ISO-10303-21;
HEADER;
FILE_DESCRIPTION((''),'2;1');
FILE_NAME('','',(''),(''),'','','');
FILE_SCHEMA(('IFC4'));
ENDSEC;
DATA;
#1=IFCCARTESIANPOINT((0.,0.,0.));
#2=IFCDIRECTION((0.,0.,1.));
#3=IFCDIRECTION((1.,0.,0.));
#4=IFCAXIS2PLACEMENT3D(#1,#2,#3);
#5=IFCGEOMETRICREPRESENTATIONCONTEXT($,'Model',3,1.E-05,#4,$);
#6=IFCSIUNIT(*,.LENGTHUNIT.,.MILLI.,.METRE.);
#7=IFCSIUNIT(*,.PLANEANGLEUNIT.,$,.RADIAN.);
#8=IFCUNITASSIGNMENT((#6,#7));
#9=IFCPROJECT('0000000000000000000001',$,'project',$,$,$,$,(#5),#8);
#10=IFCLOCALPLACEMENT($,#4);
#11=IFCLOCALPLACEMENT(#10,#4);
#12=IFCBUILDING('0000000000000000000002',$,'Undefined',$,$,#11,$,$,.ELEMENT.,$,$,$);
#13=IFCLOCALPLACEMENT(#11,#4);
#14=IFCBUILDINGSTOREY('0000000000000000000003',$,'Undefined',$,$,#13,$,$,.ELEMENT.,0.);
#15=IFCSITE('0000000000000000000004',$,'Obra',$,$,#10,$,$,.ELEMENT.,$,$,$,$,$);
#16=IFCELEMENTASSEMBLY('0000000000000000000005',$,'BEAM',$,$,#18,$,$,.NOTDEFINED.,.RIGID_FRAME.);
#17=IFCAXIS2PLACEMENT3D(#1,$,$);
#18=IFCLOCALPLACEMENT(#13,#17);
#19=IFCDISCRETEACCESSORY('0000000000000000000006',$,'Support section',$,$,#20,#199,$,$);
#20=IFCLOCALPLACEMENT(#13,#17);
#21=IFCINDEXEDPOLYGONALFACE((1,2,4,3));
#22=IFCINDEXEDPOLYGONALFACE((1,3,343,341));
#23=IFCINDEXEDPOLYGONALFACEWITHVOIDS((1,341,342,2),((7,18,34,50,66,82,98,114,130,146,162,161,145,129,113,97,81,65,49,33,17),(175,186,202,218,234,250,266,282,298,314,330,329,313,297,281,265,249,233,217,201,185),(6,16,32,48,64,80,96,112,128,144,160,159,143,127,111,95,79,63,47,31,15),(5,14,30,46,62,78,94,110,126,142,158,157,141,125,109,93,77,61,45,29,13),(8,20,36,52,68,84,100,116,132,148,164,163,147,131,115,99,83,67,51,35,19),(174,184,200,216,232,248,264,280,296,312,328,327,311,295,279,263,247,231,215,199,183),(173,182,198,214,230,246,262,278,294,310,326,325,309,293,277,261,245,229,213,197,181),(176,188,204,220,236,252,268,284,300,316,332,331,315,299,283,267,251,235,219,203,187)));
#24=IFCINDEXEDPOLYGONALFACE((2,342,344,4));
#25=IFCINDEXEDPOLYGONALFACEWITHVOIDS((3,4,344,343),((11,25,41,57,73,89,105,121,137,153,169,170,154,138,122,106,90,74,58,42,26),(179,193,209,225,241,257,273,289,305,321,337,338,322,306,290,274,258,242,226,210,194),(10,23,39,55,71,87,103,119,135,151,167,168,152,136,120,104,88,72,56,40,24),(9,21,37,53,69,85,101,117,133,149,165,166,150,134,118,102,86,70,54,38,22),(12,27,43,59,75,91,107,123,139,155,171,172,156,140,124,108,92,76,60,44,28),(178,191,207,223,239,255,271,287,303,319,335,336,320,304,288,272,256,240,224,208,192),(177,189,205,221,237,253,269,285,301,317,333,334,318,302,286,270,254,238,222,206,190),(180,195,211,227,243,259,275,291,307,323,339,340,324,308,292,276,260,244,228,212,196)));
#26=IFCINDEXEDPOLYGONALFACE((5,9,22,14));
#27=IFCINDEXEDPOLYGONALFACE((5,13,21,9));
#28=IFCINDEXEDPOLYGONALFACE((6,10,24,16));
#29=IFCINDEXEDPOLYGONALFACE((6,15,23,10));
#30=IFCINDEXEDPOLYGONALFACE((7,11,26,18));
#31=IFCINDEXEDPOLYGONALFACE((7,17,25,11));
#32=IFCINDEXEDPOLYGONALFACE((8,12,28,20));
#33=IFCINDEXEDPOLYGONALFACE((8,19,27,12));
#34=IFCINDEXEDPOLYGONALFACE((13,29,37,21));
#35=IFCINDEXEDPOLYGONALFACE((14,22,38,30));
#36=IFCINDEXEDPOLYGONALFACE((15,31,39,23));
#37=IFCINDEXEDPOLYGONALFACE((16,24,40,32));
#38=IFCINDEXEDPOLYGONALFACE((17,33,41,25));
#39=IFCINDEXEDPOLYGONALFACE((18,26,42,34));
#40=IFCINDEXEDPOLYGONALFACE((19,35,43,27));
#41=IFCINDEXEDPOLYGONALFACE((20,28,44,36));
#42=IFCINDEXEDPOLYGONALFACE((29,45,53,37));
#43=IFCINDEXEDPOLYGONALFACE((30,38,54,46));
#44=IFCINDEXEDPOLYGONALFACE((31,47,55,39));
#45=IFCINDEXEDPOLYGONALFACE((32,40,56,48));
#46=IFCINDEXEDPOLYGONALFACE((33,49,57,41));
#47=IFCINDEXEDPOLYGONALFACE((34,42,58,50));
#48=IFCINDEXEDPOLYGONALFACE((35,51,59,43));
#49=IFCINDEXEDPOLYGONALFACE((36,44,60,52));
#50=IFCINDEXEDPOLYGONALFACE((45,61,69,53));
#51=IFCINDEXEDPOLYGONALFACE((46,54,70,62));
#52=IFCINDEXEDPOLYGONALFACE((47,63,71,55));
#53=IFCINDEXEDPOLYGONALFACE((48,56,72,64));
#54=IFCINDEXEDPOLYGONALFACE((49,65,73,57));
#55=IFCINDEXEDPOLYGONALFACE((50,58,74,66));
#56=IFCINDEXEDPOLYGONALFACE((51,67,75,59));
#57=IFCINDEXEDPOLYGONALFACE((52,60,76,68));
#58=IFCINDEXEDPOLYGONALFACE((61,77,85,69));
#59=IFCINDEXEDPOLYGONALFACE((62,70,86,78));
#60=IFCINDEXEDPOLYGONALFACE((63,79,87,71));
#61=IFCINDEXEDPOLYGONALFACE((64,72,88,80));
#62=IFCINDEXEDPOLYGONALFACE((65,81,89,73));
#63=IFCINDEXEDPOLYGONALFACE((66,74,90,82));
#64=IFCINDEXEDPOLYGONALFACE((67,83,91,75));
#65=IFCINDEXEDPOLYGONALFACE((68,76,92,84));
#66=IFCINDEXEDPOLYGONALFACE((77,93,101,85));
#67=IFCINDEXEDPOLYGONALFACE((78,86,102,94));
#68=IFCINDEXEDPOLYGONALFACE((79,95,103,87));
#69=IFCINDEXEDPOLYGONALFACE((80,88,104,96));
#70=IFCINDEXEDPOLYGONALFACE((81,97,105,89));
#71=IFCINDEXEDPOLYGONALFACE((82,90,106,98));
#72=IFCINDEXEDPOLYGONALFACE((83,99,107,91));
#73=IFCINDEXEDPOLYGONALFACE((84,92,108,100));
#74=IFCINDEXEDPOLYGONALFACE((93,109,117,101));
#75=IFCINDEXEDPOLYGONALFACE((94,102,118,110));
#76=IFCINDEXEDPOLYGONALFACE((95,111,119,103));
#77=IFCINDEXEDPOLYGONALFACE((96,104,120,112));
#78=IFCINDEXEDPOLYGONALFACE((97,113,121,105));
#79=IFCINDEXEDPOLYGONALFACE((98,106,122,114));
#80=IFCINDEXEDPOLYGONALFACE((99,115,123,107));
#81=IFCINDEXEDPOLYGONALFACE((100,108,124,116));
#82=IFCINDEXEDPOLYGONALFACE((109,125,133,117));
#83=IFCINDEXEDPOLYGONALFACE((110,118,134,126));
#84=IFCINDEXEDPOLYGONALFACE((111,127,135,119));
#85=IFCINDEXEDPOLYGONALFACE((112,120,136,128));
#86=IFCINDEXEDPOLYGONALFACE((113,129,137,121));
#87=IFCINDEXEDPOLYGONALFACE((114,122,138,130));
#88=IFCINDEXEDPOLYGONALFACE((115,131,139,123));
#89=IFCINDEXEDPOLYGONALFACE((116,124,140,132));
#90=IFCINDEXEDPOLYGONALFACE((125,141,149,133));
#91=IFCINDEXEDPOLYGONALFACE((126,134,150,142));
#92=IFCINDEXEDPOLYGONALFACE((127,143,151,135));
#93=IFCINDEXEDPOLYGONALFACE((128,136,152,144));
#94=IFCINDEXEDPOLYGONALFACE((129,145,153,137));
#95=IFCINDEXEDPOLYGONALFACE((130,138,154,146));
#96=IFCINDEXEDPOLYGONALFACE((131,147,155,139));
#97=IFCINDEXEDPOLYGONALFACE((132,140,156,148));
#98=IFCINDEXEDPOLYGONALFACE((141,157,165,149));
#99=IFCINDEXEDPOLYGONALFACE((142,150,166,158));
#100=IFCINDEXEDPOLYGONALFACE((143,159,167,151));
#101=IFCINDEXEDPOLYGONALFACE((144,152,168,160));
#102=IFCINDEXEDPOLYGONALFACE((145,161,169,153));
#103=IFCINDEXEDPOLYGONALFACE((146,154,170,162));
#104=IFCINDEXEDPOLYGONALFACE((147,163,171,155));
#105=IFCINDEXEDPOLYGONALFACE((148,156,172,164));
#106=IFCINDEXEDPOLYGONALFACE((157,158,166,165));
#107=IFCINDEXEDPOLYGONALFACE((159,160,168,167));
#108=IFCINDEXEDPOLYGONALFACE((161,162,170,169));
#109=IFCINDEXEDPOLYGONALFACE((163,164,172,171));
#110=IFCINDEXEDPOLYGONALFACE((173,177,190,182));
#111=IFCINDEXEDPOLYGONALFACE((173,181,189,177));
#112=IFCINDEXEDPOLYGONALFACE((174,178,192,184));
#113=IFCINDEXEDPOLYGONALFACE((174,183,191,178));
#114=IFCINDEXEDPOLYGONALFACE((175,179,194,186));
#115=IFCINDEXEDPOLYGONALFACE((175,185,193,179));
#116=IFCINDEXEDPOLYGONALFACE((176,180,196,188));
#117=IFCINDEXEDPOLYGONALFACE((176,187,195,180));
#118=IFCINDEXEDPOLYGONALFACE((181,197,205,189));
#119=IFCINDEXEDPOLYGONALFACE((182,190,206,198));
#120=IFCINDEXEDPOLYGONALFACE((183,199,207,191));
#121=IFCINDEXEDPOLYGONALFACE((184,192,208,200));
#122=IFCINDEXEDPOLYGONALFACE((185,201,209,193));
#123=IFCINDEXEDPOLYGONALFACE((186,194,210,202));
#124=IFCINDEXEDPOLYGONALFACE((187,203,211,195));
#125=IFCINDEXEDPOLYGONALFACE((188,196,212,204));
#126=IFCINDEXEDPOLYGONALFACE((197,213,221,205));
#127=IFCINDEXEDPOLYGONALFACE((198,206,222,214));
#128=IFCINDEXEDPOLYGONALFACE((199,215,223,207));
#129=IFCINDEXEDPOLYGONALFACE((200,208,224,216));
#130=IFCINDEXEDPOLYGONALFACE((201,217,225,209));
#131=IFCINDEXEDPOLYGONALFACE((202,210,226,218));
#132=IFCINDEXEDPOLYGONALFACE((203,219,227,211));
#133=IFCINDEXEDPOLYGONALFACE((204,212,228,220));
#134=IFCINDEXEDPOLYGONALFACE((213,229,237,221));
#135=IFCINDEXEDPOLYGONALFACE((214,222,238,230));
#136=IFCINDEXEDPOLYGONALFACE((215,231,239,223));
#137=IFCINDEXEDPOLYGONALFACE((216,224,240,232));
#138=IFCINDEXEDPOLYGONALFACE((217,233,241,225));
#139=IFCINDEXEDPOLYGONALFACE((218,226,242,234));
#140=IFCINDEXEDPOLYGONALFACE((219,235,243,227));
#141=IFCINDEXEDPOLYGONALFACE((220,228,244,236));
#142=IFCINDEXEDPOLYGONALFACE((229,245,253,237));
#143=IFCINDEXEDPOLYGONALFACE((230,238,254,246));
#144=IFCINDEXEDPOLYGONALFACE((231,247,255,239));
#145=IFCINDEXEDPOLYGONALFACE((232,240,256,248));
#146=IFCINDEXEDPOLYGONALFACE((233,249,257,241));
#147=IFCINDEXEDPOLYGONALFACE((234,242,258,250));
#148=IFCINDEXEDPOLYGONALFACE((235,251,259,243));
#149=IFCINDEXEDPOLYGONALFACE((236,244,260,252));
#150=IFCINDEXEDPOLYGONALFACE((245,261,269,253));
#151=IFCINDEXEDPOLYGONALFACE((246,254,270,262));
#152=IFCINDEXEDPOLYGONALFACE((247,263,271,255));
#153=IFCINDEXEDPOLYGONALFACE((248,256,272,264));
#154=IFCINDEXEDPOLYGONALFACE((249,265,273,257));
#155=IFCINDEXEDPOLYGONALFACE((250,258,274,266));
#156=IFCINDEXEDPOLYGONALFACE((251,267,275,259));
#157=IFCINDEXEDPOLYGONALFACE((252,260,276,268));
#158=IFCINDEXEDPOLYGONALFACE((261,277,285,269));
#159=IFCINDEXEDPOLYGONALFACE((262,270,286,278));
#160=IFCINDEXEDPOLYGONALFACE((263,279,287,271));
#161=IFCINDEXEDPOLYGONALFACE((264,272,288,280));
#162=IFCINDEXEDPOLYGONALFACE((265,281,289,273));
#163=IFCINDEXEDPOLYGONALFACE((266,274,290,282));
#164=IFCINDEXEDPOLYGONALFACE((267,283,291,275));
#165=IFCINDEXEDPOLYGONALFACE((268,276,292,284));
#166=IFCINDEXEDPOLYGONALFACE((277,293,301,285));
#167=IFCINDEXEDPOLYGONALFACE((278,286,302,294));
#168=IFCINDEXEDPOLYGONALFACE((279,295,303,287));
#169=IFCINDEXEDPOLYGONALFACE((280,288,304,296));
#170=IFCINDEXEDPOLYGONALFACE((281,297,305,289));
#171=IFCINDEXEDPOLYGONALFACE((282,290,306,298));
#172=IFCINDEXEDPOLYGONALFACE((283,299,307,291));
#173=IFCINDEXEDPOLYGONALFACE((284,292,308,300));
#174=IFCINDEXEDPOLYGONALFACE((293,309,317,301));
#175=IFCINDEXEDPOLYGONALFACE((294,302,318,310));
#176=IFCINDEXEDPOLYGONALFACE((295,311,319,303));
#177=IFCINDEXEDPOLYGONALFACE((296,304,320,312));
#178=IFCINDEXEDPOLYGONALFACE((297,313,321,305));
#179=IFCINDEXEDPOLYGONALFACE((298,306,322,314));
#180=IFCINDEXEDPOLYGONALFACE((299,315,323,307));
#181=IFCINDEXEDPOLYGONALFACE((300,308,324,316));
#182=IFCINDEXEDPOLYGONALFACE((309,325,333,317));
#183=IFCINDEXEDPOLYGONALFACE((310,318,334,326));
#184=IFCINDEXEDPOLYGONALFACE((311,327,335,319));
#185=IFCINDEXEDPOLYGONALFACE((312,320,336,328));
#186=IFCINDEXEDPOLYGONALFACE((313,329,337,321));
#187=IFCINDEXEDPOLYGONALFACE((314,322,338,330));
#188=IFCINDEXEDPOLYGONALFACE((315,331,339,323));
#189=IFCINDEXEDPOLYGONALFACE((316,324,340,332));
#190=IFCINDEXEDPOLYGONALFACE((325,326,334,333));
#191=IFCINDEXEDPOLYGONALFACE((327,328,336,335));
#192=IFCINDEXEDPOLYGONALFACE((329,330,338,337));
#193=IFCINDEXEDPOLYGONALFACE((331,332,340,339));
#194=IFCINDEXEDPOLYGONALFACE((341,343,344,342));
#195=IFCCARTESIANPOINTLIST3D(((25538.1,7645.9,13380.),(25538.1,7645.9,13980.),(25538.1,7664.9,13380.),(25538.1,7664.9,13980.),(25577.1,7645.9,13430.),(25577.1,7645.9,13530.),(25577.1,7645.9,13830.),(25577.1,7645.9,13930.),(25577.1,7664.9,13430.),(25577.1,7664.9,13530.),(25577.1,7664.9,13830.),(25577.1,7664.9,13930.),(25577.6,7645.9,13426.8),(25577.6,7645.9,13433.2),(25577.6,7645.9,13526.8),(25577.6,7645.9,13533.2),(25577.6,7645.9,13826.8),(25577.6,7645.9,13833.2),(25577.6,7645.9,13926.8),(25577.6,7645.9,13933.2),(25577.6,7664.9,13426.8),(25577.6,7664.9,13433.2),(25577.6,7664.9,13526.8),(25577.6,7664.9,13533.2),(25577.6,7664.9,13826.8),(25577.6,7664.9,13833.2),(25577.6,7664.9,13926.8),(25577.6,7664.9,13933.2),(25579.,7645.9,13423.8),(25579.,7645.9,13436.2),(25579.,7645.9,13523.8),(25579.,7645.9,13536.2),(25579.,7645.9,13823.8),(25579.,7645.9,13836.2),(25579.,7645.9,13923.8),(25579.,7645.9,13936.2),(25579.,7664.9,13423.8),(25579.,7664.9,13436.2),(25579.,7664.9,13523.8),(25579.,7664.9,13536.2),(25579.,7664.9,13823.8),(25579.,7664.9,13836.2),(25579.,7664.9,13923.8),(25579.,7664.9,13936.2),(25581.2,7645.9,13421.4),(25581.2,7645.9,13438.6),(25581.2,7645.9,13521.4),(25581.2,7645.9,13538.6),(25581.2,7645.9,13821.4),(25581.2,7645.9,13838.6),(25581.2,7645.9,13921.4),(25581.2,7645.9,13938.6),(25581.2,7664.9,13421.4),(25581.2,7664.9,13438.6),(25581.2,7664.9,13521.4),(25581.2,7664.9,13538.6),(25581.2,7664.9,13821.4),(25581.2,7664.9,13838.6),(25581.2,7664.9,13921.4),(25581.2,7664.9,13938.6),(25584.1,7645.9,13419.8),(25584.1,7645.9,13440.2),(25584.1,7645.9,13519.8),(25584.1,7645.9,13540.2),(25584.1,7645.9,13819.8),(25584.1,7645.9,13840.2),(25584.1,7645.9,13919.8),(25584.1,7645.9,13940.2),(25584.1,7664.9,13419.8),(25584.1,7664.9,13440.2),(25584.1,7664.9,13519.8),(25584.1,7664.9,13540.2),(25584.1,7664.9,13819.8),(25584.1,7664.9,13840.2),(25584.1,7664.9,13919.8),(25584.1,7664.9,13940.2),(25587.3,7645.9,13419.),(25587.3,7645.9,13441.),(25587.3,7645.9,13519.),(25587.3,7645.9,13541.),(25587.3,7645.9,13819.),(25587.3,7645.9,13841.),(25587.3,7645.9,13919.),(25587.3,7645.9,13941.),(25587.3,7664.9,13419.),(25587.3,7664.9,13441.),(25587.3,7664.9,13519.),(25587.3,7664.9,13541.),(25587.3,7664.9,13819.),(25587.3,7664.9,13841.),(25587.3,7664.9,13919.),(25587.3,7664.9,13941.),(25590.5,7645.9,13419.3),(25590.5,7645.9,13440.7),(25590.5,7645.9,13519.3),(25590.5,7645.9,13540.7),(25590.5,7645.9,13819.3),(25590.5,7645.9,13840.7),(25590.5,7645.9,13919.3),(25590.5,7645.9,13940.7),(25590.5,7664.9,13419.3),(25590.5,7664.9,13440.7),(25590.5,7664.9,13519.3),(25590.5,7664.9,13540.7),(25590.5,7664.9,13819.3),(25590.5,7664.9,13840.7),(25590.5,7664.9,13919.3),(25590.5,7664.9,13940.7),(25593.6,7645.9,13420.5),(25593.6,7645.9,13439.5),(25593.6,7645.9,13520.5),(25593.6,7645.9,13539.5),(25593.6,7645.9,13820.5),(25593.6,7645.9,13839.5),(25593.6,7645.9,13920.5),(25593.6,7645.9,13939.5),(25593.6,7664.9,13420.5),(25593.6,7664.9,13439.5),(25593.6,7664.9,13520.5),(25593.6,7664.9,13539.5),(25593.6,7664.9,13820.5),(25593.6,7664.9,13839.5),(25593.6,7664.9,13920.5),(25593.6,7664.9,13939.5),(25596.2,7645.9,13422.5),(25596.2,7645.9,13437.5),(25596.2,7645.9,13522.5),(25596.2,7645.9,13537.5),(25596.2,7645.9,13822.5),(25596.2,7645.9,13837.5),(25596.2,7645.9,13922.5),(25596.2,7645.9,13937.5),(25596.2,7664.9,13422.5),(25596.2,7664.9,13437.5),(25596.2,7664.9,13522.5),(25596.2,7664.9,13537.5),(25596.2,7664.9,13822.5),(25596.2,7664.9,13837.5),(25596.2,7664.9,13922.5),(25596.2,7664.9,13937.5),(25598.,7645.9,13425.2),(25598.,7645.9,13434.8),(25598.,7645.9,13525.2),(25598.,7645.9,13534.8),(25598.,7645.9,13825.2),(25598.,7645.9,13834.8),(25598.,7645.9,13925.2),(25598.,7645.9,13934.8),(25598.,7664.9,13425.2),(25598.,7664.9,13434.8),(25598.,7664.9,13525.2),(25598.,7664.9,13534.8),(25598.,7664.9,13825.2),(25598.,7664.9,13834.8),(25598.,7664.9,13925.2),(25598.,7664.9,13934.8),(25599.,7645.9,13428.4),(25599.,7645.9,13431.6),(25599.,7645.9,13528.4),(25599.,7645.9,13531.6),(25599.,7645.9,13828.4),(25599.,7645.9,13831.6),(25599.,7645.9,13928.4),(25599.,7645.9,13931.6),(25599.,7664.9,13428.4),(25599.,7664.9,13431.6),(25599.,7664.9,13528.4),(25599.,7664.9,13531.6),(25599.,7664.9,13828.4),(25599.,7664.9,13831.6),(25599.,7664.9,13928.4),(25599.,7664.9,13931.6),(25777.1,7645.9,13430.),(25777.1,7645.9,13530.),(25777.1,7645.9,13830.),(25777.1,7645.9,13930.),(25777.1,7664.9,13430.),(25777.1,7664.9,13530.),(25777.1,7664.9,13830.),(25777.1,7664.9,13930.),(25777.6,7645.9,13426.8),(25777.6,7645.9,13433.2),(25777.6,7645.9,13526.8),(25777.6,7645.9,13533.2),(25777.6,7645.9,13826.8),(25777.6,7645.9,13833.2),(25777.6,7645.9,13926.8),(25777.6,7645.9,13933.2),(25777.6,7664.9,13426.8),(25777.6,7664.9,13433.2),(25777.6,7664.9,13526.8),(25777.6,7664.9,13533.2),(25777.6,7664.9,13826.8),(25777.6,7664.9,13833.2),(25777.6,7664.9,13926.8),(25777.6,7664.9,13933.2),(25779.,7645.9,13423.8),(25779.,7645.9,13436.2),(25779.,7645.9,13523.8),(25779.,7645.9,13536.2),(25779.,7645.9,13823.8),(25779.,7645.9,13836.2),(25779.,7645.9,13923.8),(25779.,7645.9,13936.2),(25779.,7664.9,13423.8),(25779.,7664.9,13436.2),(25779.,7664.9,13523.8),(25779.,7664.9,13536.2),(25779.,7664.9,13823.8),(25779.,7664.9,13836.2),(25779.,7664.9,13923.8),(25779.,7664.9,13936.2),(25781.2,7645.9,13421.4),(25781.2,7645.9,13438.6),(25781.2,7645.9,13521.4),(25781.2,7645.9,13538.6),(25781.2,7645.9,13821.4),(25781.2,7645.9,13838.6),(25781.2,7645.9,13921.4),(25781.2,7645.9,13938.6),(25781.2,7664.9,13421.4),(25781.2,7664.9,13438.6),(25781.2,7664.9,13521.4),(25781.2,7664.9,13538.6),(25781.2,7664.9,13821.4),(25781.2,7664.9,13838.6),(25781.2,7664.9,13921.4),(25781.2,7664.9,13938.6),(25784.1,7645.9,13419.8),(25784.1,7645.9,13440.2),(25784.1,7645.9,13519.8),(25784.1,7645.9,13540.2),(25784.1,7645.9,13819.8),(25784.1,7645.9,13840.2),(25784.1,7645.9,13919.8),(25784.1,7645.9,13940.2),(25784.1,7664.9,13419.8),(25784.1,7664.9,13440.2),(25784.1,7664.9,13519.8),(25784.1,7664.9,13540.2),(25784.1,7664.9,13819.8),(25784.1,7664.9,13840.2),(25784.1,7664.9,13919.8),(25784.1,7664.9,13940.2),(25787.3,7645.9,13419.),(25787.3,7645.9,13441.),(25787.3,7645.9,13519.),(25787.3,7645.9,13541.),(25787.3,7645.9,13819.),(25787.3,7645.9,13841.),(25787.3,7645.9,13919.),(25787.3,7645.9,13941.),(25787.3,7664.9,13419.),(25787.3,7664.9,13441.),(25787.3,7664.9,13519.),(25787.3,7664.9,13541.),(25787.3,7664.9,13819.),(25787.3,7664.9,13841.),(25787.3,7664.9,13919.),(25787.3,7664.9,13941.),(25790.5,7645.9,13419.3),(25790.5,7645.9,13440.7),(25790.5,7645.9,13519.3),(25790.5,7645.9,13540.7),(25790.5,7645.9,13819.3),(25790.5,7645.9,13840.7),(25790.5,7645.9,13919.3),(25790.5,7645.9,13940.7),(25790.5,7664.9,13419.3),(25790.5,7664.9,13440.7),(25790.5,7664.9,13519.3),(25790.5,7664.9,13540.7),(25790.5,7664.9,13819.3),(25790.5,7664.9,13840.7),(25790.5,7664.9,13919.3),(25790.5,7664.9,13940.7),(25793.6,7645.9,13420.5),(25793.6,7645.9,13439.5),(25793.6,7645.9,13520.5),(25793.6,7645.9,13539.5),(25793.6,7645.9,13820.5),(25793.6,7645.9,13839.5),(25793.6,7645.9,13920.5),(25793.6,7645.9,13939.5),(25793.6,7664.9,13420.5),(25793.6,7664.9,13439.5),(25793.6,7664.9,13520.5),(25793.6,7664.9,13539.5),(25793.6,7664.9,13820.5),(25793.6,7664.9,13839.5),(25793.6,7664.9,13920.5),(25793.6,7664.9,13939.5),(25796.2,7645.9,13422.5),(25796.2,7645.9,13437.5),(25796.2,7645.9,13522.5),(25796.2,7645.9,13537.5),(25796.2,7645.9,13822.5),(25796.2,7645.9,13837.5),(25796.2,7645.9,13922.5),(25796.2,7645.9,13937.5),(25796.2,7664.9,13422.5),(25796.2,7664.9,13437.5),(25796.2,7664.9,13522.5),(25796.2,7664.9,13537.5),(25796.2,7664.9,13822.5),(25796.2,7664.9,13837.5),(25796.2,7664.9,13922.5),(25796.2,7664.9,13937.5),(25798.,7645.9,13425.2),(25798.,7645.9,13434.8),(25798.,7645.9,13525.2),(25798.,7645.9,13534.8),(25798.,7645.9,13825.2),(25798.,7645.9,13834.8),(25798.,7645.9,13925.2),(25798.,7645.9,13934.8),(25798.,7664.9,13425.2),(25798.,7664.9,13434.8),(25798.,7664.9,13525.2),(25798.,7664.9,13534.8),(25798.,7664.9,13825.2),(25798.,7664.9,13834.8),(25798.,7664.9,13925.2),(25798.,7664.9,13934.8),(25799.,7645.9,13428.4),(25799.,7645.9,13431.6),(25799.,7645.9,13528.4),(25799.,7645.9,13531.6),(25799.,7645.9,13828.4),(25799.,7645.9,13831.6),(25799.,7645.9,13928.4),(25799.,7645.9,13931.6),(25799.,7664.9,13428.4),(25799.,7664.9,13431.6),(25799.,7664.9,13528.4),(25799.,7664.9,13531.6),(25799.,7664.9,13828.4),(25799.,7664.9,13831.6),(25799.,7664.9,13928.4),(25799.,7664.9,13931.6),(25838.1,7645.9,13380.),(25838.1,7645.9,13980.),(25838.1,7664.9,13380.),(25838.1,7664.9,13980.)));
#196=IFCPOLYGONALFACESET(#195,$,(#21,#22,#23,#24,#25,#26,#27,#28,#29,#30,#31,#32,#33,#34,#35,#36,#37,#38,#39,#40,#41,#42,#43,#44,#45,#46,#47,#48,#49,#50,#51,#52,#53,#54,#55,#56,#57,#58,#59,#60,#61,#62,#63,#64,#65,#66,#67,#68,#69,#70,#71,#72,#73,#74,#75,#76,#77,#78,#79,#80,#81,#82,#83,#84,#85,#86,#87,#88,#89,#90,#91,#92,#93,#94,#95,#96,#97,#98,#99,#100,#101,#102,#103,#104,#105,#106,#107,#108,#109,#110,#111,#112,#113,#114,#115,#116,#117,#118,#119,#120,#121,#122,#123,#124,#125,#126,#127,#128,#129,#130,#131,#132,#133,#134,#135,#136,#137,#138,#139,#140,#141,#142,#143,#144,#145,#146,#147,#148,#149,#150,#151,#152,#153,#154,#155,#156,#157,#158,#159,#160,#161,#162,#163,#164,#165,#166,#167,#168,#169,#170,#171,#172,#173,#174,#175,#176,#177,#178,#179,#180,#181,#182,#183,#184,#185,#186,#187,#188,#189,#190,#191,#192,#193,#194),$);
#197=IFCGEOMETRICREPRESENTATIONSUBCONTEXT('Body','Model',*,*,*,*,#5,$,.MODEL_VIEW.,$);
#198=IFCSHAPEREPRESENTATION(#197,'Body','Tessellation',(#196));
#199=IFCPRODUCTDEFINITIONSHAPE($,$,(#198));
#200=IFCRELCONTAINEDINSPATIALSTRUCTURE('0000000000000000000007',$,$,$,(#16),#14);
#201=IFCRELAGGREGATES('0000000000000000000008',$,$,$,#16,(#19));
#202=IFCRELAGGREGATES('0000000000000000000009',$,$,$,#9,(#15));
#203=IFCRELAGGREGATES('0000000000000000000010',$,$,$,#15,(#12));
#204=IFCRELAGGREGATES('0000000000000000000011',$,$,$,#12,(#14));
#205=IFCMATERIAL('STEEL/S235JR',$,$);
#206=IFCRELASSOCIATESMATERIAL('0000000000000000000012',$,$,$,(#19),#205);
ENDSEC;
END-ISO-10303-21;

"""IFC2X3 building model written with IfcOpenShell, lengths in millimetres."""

from ifc_helpers import new_model, si_unit, frame, origin_with_axes, origin_2d_with_axis, place, context, subcontext, project, spatial, rectangle, circle, extrude, source, transform, mapped, material, element, aggregate, save


model = new_model("IFC2X3")

# Units and contexts
model_context = context("Model", 3, precision=1e-05, world=origin_with_axes())
body_context = subcontext(model_context, "Body", "Model", "MODEL_VIEW")
ifc_project = project(units=[si_unit("LENGTHUNIT", "METRE", prefix="MILLI"), si_unit("PLANEANGLEUNIT", "RADIAN")], contexts=[model_context])

# Site, building, storey
site_placement = place(None, origin_with_axes())
site = spatial("IfcSite", under=ifc_project, at=site_placement, Name="Obra", CompositionType="ELEMENT")
building_placement = place(site_placement, origin_with_axes())
building = spatial("IfcBuilding", under=site, at=building_placement, Name="Undefined", CompositionType="ELEMENT")
storey_placement = place(building_placement, origin_with_axes())
storey = spatial("IfcBuildingStorey", under=building, at=storey_placement, Name="Undefined", CompositionType="ELEMENT", Elevation=0.0)

# Element assembly
assembly_1_placement = place(storey_placement, origin_with_axes())
assembly_1 = element("IfcElementAssembly", 1, at=assembly_1_placement, inside=storey, Name="BEAM", AssemblyPlace="NOTDEFINED", PredefinedType="RIGID_FRAME")
ifc_material_1 = material(Name="STEEL/S235JR")

# Shared definitions
shared_shape_1 = source(origin_with_axes(), body_context, "Body", "SweptSolid", [
    extrude(circle(Radius=11.0, at=origin_2d_with_axis()), frame((0.0, -0.1, 0.0), z_axis=(0.0, 1.0, 0.0), x_axis=(1.0, 0.0, 0.0)), (0.0, 0.0, 1.0), 19.2),
])

# Discrete accessory, opening
discrete_accessory_1_placement = place(assembly_1_placement, frame((25538.1, 7655.4, 13680.0), z_axis=(0.0, 0.0, 1.0), x_axis=(1.0, 0.0, 0.0)))
discrete_accessory_1 = element("IfcDiscreteAccessory", 2, at=discrete_accessory_1_placement, material=ifc_material_1, Name="Support section", context=body_context, shape_type="SweptSolid", body=[
    extrude(rectangle(XDim=19.0, YDim=600.0, at=origin_2d_with_axis()), frame((300.0, 0.0, 0.0), z_axis=(-1.0, 0.0, 0.0), x_axis=(0.0, -1.0, 0.0)), (0.0, 0.0, 1.0), 300.0),
])
opening_1_placement = place(assembly_1_placement, frame((25838.2, 7664.9, 13680.0), z_axis=(0.0, 0.0, 1.0), x_axis=(-1.0, 0.0, 0.0)))
element("IfcOpeningElement", 3, at=opening_1_placement, cuts=discrete_accessory_1, ObjectType="Opening", context=body_context, shape_type="MappedRepresentation", body=[
    mapped(shared_shape_1, transform((50.1, 0.0, -250.0))),
    mapped(shared_shape_1, transform((50.1, 0.0, -150.0))),
    mapped(shared_shape_1, transform((50.1, 0.0, 150.0))),
    mapped(shared_shape_1, transform((50.1, 0.0, 250.0))),
    mapped(shared_shape_1, transform((250.1, 0.0, -250.0))),
    mapped(shared_shape_1, transform((250.1, 0.0, -150.0))),
    mapped(shared_shape_1, transform((250.1, 0.0, 150.0))),
    mapped(shared_shape_1, transform((250.1, 0.0, 250.0))),
])
aggregate(assembly_1, [discrete_accessory_1])

save(model, "model.ifc")
